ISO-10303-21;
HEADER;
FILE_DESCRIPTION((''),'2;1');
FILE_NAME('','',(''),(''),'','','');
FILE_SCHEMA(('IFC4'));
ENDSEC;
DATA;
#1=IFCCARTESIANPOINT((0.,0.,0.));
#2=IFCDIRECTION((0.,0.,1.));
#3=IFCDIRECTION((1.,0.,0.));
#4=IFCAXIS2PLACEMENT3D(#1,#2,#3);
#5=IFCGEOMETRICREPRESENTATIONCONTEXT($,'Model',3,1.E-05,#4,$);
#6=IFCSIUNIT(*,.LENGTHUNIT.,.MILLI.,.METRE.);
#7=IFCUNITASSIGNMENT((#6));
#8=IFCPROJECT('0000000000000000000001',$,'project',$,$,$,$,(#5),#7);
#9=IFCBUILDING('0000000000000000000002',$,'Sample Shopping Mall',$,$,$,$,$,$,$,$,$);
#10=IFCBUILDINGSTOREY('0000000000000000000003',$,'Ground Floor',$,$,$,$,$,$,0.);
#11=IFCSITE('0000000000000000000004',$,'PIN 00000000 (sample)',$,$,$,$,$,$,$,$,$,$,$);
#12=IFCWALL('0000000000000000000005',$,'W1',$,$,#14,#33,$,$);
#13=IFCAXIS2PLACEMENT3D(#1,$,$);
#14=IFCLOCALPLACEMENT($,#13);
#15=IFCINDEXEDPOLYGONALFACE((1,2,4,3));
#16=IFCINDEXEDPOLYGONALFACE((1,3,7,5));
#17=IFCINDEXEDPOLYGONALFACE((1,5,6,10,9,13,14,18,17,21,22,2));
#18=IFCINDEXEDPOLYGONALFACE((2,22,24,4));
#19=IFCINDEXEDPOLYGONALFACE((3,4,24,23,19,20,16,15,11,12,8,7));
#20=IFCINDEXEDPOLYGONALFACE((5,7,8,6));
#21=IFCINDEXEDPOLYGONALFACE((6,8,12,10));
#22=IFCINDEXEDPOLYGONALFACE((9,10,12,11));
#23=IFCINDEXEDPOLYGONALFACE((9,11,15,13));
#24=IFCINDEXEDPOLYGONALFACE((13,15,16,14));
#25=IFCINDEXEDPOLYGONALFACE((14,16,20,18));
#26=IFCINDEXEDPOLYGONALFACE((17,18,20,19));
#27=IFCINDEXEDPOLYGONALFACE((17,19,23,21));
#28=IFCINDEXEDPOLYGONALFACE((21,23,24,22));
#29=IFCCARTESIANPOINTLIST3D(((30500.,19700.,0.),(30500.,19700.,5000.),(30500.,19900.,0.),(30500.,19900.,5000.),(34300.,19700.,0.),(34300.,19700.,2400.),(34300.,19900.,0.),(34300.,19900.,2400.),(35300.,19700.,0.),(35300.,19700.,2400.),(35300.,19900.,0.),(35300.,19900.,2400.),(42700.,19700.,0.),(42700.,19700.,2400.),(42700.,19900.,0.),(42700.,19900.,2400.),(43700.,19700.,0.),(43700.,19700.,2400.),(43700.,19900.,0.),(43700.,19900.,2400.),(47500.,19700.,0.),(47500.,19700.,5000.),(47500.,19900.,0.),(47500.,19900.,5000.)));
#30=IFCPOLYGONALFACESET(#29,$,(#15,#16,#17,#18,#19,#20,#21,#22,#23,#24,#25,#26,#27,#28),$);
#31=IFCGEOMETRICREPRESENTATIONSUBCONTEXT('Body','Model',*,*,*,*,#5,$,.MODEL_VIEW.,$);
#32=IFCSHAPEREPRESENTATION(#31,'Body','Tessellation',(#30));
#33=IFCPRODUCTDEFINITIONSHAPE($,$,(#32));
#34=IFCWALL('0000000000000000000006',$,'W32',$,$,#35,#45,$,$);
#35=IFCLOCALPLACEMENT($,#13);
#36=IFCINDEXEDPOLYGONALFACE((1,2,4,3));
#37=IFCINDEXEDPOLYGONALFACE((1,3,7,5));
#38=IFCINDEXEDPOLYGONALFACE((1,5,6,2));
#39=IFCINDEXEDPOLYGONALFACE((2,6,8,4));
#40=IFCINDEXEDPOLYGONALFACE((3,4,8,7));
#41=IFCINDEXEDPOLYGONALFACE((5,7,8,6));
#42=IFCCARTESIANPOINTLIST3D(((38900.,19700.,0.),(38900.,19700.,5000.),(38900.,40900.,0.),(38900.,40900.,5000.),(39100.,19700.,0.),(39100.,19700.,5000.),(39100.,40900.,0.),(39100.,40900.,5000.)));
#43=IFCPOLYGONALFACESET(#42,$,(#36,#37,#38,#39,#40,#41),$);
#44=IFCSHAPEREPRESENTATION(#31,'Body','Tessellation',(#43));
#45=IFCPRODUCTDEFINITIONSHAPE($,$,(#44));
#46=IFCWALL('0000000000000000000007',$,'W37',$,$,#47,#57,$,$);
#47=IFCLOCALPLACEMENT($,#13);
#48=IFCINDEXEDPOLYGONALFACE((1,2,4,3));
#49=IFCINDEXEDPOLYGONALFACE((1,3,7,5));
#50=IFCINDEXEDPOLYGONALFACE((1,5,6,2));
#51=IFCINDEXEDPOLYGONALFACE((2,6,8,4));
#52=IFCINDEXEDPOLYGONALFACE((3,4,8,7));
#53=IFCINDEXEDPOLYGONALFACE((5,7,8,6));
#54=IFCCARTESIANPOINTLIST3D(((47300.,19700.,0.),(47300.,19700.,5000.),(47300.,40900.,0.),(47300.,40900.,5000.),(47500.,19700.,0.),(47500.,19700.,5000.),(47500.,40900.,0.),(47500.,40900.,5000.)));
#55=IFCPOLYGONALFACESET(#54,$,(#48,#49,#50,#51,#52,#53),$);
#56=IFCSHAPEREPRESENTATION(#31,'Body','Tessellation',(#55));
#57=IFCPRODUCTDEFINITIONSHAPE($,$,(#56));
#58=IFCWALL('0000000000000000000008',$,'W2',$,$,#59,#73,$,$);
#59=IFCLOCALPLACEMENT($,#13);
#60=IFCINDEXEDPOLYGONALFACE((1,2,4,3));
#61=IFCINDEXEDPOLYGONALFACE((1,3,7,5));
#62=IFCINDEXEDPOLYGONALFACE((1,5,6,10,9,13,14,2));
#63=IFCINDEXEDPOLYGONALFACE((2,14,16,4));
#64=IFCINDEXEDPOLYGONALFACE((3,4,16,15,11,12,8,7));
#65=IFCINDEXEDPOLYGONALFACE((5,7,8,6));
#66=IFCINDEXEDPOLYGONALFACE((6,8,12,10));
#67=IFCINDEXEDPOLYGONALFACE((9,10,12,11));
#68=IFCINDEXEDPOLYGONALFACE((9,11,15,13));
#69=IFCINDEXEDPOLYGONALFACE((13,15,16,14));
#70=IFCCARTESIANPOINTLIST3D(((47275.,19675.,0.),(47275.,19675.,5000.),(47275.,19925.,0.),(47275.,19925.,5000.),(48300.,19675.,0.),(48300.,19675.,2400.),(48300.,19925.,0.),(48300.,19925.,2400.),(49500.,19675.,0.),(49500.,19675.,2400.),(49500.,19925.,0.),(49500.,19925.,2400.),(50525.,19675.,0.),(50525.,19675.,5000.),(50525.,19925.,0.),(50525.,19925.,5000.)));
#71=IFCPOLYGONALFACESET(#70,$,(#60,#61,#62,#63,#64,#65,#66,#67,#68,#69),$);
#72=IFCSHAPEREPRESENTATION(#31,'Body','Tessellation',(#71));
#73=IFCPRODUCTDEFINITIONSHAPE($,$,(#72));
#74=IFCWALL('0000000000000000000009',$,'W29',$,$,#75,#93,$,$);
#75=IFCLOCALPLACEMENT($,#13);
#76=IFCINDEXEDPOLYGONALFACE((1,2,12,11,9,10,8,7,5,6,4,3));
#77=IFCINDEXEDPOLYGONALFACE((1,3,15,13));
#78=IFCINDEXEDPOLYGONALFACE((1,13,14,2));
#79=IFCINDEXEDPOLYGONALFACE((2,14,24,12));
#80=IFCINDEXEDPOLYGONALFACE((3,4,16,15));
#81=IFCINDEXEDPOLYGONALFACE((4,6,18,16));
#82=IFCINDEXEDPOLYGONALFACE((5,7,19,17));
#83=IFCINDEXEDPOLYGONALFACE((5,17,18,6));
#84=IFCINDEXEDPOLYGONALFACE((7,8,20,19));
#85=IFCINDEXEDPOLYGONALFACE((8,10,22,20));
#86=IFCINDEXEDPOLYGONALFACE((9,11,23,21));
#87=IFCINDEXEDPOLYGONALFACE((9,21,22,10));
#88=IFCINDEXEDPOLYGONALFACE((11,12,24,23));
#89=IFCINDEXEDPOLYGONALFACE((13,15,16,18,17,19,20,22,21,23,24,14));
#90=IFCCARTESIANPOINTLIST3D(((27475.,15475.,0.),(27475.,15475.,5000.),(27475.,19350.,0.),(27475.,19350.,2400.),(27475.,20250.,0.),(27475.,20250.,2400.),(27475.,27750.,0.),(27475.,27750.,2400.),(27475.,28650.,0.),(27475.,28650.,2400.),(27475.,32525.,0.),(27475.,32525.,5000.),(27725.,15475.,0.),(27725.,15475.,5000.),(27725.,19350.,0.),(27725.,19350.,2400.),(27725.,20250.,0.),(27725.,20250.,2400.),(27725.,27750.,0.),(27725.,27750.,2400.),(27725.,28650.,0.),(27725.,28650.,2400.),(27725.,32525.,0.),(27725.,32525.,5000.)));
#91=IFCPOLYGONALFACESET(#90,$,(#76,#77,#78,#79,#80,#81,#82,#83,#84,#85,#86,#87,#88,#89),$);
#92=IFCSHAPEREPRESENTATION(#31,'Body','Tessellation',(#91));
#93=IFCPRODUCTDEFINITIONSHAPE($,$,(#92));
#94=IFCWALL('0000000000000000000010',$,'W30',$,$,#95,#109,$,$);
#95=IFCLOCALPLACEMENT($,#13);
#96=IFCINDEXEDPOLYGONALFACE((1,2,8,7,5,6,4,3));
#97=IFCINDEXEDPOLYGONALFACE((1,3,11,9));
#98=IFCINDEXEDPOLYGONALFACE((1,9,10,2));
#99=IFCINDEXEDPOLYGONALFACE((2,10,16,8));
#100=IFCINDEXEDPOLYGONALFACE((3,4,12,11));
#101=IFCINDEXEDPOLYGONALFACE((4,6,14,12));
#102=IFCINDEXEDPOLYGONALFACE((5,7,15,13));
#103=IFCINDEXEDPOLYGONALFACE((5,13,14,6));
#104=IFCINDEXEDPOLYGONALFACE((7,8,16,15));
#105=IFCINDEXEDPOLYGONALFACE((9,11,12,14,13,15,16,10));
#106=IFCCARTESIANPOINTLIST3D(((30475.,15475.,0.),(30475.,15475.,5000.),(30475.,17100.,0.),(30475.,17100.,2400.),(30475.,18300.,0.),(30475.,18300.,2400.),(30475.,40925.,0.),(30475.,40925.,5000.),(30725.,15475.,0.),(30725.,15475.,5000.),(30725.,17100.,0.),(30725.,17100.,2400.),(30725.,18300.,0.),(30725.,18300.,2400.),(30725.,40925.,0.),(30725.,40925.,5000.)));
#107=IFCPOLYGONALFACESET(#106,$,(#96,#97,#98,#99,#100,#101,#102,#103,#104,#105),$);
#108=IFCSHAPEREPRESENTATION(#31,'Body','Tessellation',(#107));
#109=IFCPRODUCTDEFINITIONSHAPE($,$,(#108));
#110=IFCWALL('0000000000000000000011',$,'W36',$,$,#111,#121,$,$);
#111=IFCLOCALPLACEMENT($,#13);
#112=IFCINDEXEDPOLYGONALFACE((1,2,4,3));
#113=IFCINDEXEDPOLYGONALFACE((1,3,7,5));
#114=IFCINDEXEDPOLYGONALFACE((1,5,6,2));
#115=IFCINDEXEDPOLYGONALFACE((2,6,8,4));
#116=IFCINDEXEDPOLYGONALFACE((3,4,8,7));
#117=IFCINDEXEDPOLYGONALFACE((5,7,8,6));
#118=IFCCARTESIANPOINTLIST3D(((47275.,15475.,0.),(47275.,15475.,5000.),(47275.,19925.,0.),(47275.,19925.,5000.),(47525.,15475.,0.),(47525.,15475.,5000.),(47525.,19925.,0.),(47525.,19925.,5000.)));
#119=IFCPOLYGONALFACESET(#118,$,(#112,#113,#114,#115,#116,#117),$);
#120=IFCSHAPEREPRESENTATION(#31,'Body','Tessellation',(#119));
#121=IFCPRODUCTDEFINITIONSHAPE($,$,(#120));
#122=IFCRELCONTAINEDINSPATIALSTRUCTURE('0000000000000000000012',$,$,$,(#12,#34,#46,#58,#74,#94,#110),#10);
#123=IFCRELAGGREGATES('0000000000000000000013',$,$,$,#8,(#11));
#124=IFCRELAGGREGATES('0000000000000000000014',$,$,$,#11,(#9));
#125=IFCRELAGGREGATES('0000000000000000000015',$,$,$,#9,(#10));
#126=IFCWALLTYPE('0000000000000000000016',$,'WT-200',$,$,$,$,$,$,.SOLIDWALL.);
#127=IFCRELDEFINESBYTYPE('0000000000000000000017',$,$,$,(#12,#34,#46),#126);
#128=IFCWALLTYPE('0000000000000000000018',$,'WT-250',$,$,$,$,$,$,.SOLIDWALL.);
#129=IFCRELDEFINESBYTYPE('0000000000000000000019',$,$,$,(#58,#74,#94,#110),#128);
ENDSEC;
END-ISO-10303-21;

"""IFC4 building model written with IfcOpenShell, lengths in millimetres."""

from ifc_helpers import new_model, si_unit, frame, origin_with_axes, place, context, subcontext, project, spatial, indexed_curve, outline, extrude, type_object, element, save


model = new_model("IFC4")

# Units and contexts
model_context = context("Model", 3, precision=1e-05, world=origin_with_axes())
body_context = subcontext(model_context, "Body", "Model", "MODEL_VIEW")
ifc_project = project(units=[si_unit("LENGTHUNIT", "METRE", prefix="MILLI")], contexts=[model_context])

# Site, building, storey
site = spatial("IfcSite", under=ifc_project, Name="PIN 00000000 (sample)")
building = spatial("IfcBuilding", under=site, Name="Sample Shopping Mall")
storey = spatial("IfcBuildingStorey", under=building, Name="Ground Floor", Elevation=0.0)

# Wall, openings
wall_type_1 = type_object("IfcWallType", Name="WT-200", PredefinedType="SOLIDWALL")
wall_1_placement = place(None, frame((30500.0, 19700.0, 0.0), z_axis=(0.0, 0.0, 1.0), x_axis=(1.0, 0.0, 0.0)))
wall_1 = element("IfcWall", 1, at=wall_1_placement, inside=storey, type_object=wall_type_1, Name="W1", context=body_context, shape_type="SweptSolid", body=[
    extrude(outline(indexed_curve([(0.0, 0.0), (0.0, 200.0), (17000.0, 200.0), (17000.0, 0.0), (0.0, 0.0)], self_intersect=False)), origin_with_axes(), (0.0, 0.0, 1.0), 5000.0),
])
opening_1_placement = place(wall_1_placement, frame((3800.0, -100.0, 0.0), z_axis=(0.0, 0.0, 1.0), x_axis=(1.0, 0.0, 0.0)))
element("IfcOpeningElement", 2, at=opening_1_placement, cuts=wall_1, context=body_context, shape_type="SweptSolid", body=[
    extrude(outline(indexed_curve([(0.0, 0.0), (0.0, 400.0), (1000.0, 400.0), (1000.0, 0.0), (0.0, 0.0)], self_intersect=False)), origin_with_axes(), (0.0, 0.0, 1.0), 2400.0),
])
opening_2_placement = place(wall_1_placement, frame((12200.0, -100.0, 0.0), z_axis=(0.0, 0.0, 1.0), x_axis=(1.0, 0.0, 0.0)))
element("IfcOpeningElement", 3, at=opening_2_placement, cuts=wall_1, context=body_context, shape_type="SweptSolid", body=[
    extrude(outline(indexed_curve([(0.0, 0.0), (0.0, 400.0), (1000.0, 400.0), (1000.0, 0.0), (0.0, 0.0)], self_intersect=False)), origin_with_axes(), (0.0, 0.0, 1.0), 2400.0),
])

# Walls
for number, where, z_axis, x_axis, name in (
    (4, (39100.0, 19700.0, 0.0), (0.0, 0.0, 1.0), (0.0, 1.0, 0.0), "W32"),
    (5, (47500.0, 19700.0, 0.0), (0.0, 0.0, 1.0), (0.0, 1.0, 0.0), "W37"),
):
    element("IfcWall", number, at=place(None, frame(where, z_axis=z_axis, x_axis=x_axis)), inside=storey, type_object=wall_type_1, Name=name, context=body_context, shape_type="SweptSolid", body=[
        extrude(outline(indexed_curve([(0.0, 0.0), (0.0, 200.0), (21200.0, 200.0), (21200.0, 0.0), (0.0, 0.0)], self_intersect=False)), origin_with_axes(), (0.0, 0.0, 1.0), 5000.0),
    ])

# Wall, opening
wall_type_2 = type_object("IfcWallType", Name="WT-250", PredefinedType="SOLIDWALL")
wall_2_placement = place(None, frame((47275.0, 19675.0, 0.0), z_axis=(0.0, 0.0, 1.0), x_axis=(1.0, 0.0, 0.0)))
wall_2 = element("IfcWall", 6, at=wall_2_placement, inside=storey, type_object=wall_type_2, Name="W2", context=body_context, shape_type="SweptSolid", body=[
    extrude(outline(indexed_curve([(0.0, 0.0), (0.0, 250.0), (3250.0, 250.0), (3250.0, 0.0), (0.0, 0.0)], self_intersect=False)), origin_with_axes(), (0.0, 0.0, 1.0), 5000.0),
])
opening_3_placement = place(wall_2_placement, frame((1025.0, -100.0, 0.0), z_axis=(0.0, 0.0, 1.0), x_axis=(1.0, 0.0, 0.0)))
element("IfcOpeningElement", 7, at=opening_3_placement, cuts=wall_2, context=body_context, shape_type="SweptSolid", body=[
    extrude(outline(indexed_curve([(0.0, 0.0), (0.0, 450.0), (1200.0, 450.0), (1200.0, 0.0), (0.0, 0.0)], self_intersect=False)), origin_with_axes(), (0.0, 0.0, 1.0), 2400.0),
])

# Wall, openings
wall_3_placement = place(None, frame((27725.0, 15475.0, 0.0), z_axis=(0.0, 0.0, 1.0), x_axis=(0.0, 1.0, 0.0)))
wall_3 = element("IfcWall", 8, at=wall_3_placement, inside=storey, type_object=wall_type_2, Name="W29", context=body_context, shape_type="SweptSolid", body=[
    extrude(outline(indexed_curve([(0.0, 0.0), (0.0, 250.0), (17050.0, 250.0), (17050.0, 0.0), (0.0, 0.0)], self_intersect=False)), origin_with_axes(), (0.0, 0.0, 1.0), 5000.0),
])
opening_4_placement = place(wall_3_placement, frame((12275.0, -100.0, 0.0), z_axis=(0.0, 0.0, 1.0), x_axis=(1.0, 0.0, 0.0)))
element("IfcOpeningElement", 9, at=opening_4_placement, cuts=wall_3, context=body_context, shape_type="SweptSolid", body=[
    extrude(outline(indexed_curve([(0.0, 0.0), (0.0, 450.0), (900.0, 450.0), (900.0, 0.0), (0.0, 0.0)], self_intersect=False)), origin_with_axes(), (0.0, 0.0, 1.0), 2400.0),
])
opening_5_placement = place(wall_3_placement, frame((3875.0, -100.0, 0.0), z_axis=(0.0, 0.0, 1.0), x_axis=(1.0, 0.0, 0.0)))
element("IfcOpeningElement", 10, at=opening_5_placement, cuts=wall_3, context=body_context, shape_type="SweptSolid", body=[
    extrude(outline(indexed_curve([(0.0, 0.0), (0.0, 450.0), (900.0, 450.0), (900.0, 0.0), (0.0, 0.0)], self_intersect=False)), origin_with_axes(), (0.0, 0.0, 1.0), 2400.0),
])

# Wall, opening
wall_4_placement = place(None, frame((30725.0, 15475.0, 0.0), z_axis=(0.0, 0.0, 1.0), x_axis=(0.0, 1.0, 0.0)))
wall_4 = element("IfcWall", 11, at=wall_4_placement, inside=storey, type_object=wall_type_2, Name="W30", context=body_context, shape_type="SweptSolid", body=[
    extrude(outline(indexed_curve([(0.0, 0.0), (0.0, 250.0), (25450.0, 250.0), (25450.0, 0.0), (0.0, 0.0)], self_intersect=False)), origin_with_axes(), (0.0, 0.0, 1.0), 5000.0),
])
opening_6_placement = place(wall_4_placement, frame((1625.0, -100.0, 0.0), z_axis=(0.0, 0.0, 1.0), x_axis=(1.0, 0.0, 0.0)))
element("IfcOpeningElement", 12, at=opening_6_placement, cuts=wall_4, context=body_context, shape_type="SweptSolid", body=[
    extrude(outline(indexed_curve([(0.0, 0.0), (0.0, 450.0), (1200.0, 450.0), (1200.0, 0.0), (0.0, 0.0)], self_intersect=False)), origin_with_axes(), (0.0, 0.0, 1.0), 2400.0),
])

# Wall
wall_5_placement = place(None, frame((47525.0, 15475.0, 0.0), z_axis=(0.0, 0.0, 1.0), x_axis=(0.0, 1.0, 0.0)))
element("IfcWall", 13, at=wall_5_placement, inside=storey, type_object=wall_type_2, Name="W36", context=body_context, shape_type="SweptSolid", body=[
    extrude(outline(indexed_curve([(0.0, 0.0), (0.0, 250.0), (4450.0, 250.0), (4450.0, 0.0), (0.0, 0.0)], self_intersect=False)), origin_with_axes(), (0.0, 0.0, 1.0), 5000.0),
])

save(model, "model.ifc")
